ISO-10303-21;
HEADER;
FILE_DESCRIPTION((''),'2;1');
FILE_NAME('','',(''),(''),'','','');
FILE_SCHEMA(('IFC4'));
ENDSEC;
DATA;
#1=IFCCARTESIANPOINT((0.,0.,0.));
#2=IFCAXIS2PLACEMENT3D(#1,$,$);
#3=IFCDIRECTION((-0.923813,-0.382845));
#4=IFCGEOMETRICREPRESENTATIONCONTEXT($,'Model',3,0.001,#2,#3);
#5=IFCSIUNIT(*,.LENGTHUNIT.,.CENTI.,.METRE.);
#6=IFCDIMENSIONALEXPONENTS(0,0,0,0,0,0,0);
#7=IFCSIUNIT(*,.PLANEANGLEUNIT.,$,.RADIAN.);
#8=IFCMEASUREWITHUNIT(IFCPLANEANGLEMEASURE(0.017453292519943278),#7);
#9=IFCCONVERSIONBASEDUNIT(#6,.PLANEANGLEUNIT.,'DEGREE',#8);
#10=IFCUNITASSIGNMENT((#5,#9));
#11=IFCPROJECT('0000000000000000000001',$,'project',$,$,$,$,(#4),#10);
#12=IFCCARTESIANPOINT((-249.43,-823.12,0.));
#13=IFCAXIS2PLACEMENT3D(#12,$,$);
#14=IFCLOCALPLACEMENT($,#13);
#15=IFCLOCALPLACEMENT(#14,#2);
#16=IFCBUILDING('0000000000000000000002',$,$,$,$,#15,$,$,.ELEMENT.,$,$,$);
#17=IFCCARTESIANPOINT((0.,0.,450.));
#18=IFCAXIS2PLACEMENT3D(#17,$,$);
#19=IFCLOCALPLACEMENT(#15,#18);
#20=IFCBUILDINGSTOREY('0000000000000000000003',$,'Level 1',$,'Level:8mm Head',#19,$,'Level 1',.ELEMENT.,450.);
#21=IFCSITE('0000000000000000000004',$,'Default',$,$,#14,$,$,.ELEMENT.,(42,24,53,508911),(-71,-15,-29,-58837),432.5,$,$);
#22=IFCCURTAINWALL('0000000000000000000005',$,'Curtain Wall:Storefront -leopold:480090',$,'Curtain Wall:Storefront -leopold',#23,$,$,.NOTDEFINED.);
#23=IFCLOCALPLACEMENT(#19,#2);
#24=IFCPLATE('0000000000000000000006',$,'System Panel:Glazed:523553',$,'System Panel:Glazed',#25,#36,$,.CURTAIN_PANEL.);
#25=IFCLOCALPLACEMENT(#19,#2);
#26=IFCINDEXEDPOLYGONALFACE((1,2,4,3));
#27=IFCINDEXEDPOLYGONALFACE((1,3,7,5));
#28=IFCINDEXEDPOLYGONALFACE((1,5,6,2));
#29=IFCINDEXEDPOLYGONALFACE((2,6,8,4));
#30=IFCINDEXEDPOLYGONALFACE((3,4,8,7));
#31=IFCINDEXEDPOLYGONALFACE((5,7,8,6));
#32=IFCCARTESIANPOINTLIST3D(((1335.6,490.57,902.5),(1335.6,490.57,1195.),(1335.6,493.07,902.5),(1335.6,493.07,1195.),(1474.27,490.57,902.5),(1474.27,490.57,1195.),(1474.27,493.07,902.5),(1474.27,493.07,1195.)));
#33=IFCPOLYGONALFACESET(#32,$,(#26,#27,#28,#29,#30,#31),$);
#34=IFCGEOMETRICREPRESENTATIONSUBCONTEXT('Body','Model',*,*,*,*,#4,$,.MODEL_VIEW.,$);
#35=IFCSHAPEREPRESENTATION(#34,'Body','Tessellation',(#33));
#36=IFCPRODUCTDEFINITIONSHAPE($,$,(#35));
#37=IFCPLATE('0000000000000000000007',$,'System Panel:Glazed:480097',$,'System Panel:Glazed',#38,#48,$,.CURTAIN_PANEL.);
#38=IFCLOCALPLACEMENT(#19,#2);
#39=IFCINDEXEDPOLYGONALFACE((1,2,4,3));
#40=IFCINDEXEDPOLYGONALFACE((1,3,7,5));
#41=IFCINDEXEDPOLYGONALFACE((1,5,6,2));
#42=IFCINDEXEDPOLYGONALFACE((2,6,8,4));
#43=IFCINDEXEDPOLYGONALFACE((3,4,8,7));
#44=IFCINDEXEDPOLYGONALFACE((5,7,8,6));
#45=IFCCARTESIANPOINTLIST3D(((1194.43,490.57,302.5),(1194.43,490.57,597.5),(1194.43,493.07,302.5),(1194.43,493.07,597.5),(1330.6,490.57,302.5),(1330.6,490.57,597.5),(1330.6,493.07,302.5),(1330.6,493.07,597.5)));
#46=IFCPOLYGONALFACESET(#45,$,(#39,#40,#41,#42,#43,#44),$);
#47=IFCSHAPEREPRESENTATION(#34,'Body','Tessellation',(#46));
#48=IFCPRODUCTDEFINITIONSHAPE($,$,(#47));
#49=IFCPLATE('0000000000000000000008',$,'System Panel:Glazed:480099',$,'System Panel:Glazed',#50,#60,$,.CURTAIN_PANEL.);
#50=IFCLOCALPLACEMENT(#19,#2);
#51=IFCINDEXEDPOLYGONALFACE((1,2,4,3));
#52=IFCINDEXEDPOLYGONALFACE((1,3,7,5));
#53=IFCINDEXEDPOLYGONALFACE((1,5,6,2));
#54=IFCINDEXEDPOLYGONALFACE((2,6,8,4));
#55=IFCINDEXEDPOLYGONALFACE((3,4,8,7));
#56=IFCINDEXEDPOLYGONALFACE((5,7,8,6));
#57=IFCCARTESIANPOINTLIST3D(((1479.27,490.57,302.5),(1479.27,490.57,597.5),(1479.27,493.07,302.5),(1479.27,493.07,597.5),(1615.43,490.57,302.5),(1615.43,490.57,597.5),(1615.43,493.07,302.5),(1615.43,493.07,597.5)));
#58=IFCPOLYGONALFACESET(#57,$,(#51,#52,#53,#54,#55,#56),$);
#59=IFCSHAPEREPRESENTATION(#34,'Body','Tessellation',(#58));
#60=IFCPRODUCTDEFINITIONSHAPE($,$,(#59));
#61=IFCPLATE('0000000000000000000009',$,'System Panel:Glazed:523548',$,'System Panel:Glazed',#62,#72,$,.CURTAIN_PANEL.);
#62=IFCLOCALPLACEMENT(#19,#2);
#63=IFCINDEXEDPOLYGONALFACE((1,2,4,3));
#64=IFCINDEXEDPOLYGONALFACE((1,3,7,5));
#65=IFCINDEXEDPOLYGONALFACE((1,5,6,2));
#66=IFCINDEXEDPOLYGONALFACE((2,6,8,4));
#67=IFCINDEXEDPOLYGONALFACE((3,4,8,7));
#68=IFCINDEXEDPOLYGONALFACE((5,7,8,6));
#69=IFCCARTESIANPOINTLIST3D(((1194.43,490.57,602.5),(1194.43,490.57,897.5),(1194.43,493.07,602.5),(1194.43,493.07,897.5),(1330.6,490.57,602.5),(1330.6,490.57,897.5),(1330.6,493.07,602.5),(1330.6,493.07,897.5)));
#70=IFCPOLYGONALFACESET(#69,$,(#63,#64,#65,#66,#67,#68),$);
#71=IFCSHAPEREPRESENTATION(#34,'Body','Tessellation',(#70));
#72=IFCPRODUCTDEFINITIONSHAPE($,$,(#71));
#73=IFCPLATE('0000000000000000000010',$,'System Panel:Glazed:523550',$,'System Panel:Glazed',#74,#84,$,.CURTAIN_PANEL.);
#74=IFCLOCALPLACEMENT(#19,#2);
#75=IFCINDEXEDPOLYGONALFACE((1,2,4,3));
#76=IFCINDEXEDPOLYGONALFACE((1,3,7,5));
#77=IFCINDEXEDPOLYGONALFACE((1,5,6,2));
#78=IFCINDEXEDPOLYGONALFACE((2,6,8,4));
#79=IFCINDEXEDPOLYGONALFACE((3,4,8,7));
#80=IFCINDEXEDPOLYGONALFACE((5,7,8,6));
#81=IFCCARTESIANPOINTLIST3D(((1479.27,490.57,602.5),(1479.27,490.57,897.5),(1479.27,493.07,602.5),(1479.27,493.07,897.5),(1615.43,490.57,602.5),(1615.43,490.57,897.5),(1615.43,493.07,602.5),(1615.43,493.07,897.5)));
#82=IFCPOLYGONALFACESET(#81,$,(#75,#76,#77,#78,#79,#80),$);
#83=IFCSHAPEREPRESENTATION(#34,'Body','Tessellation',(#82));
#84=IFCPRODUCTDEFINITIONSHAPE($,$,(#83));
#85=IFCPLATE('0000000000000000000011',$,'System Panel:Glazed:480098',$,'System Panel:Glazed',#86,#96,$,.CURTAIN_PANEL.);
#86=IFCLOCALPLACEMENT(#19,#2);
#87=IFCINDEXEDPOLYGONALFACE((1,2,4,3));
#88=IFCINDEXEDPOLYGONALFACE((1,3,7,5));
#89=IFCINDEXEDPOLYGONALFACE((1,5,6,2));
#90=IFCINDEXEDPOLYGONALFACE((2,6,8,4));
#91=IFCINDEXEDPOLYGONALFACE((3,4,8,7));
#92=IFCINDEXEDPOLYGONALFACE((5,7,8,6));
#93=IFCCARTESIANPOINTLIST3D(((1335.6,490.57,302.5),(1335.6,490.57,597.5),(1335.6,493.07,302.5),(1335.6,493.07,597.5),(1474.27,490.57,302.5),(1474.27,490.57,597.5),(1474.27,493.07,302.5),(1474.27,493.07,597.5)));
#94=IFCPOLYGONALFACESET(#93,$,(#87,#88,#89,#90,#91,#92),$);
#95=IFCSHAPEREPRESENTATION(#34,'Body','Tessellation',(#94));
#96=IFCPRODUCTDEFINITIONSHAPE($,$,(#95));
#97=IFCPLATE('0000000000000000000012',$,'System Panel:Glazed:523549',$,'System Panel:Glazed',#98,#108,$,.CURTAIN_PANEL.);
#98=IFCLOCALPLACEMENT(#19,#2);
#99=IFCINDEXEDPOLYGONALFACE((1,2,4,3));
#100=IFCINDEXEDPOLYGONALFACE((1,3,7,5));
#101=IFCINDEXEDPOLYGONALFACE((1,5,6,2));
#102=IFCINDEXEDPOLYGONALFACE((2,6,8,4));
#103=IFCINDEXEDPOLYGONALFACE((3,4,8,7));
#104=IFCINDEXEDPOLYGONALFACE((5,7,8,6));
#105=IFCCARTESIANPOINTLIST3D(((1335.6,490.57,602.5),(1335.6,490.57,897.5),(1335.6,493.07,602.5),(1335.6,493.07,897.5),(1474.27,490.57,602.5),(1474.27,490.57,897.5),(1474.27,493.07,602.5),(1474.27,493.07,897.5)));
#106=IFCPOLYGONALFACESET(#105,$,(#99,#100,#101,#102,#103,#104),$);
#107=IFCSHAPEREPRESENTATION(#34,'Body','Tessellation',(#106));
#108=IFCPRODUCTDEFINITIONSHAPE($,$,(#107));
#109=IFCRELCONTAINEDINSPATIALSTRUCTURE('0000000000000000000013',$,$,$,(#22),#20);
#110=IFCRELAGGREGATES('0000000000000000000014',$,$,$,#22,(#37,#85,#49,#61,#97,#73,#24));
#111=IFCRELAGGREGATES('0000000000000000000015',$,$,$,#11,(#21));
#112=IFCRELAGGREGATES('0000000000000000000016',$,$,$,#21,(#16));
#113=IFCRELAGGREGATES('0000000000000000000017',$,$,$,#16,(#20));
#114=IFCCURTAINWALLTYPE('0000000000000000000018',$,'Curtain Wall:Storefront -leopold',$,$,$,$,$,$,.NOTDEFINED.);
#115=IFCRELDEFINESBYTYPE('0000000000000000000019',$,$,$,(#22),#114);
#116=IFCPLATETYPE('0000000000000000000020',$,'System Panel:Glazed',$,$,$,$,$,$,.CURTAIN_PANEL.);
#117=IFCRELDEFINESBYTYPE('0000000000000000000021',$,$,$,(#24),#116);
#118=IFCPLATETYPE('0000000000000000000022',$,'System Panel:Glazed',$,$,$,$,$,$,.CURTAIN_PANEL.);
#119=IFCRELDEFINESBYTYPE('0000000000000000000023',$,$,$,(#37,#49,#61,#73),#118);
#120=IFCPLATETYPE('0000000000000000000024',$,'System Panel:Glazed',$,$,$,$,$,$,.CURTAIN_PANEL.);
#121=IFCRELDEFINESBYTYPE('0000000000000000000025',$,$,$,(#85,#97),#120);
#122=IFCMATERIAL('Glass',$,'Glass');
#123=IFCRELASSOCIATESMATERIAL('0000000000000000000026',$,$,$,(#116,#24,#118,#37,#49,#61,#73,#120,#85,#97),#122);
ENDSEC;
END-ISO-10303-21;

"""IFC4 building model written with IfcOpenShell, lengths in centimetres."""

from ifc_helpers import new_model, entity, si_unit, converted_unit, direction, frame, origin, place, context, subcontext, project, spatial, indexed_curve, outline, extrude, source, transform, mapped, material, type_object, type_shapes, element, aggregate, save


model = new_model("IFC4")

# Units and contexts
model_context = context("Model", 3, precision=0.001, world=origin(), true_north=direction((-0.923813, -0.382845)))
body_context = subcontext(model_context, "Body", "Model", "MODEL_VIEW")
ifc_project = project(units=[si_unit("LENGTHUNIT", "METRE", prefix="CENTI"), converted_unit("PLANEANGLEUNIT", "DEGREE", entity("IfcPlaneAngleMeasure", 0.017453292519943278), si_unit("PLANEANGLEUNIT", "RADIAN"), dimensions=[0, 0, 0, 0, 0, 0, 0])], contexts=[model_context])

# Site, building, storey
site_placement = place(None, frame((-249.43, -823.12, 0.0)))
site = spatial("IfcSite", under=ifc_project, at=site_placement, Name="Default", CompositionType="ELEMENT", RefLatitude=(42, 24, 53, 508911), RefLongitude=(-71, -15, -29, -58837), RefElevation=432.5)
building_placement = place(site_placement, origin())
building = spatial("IfcBuilding", under=site, at=building_placement, CompositionType="ELEMENT")
storey_placement = place(building_placement, frame((0.0, 0.0, 450.0)))
storey = spatial("IfcBuildingStorey", under=building, at=storey_placement, Name="Level 1", ObjectType="Level:8mm Head", LongName="Level 1", CompositionType="ELEMENT", Elevation=450.0)

# Curtain wall, plates
curtain_wall_type = type_object("IfcCurtainWallType", Name="Curtain Wall:Storefront -leopold", PredefinedType="NOTDEFINED")
curtain_wall_placement = place(storey_placement, frame((0.0, 0.0, -450.0)))
curtain_wall = element("IfcCurtainWall", 1, at=curtain_wall_placement, inside=storey, type_object=curtain_wall_type, Name="Curtain Wall:Storefront -leopold:480090", ObjectType="Curtain Wall:Storefront -leopold", PredefinedType="NOTDEFINED")
ifc_material_1 = material(Name="Glass", Category="Glass")
plate_type_1 = type_object("IfcPlateType", Name="System Panel:Glazed", PredefinedType="CURTAIN_PANEL", material=ifc_material_1)
shared_shape_1 = source(origin(), body_context, "Body", "SweptSolid", [
    extrude(outline(indexed_curve([(-1.25, -69.33), (1.25, -69.33), (1.25, 69.33), (-1.25, 69.33), (-1.25, -69.33)], self_intersect=False)), frame((0.0, 3.7, 0.0), z_axis=(0.0, 0.0, 1.0), x_axis=(0.0, 1.0, 0.0)), (0.0, 0.0, 1.0), 292.5),
])
type_shapes(plate_type_1, [shared_shape_1])
plate_1_placement = place(curtain_wall_placement, frame((1404.93, 488.12, 1352.5)))
plate_1 = element("IfcPlate", 2, at=plate_1_placement, type_object=plate_type_1, material=ifc_material_1, Name="System Panel:Glazed:523553", ObjectType="System Panel:Glazed", PredefinedType="CURTAIN_PANEL", context=body_context, shape_type="MappedRepresentation", body=[
    mapped(shared_shape_1, transform((0.0, 0.0, 0.0), scale=1.0)),
])
plate_type_2 = type_object("IfcPlateType", Name="System Panel:Glazed", PredefinedType="CURTAIN_PANEL", material=ifc_material_1)
shared_shape_2 = source(origin(), body_context, "Body", "SweptSolid", [
    extrude(outline(indexed_curve([(-1.25, -68.08), (1.25, -68.08), (1.25, 68.08), (-1.25, 68.08), (-1.25, -68.08)], self_intersect=False)), frame((0.0, 3.7, 0.0), z_axis=(0.0, 0.0, 1.0), x_axis=(0.0, 1.0, 0.0)), (0.0, 0.0, 1.0), 295.0),
])
type_shapes(plate_type_2, [shared_shape_2])
plate_2_placement = place(curtain_wall_placement, frame((1262.52, 488.12, 752.5)))
plate_2 = element("IfcPlate", 3, at=plate_2_placement, type_object=plate_type_2, material=ifc_material_1, Name="System Panel:Glazed:480097", ObjectType="System Panel:Glazed", PredefinedType="CURTAIN_PANEL", context=body_context, shape_type="MappedRepresentation", body=[
    mapped(shared_shape_2, transform((0.0, 0.0, 0.0), scale=1.0)),
])
plate_3_placement = place(curtain_wall_placement, frame((1547.35, 488.12, 752.5)))
plate_3 = element("IfcPlate", 4, at=plate_3_placement, type_object=plate_type_2, material=ifc_material_1, Name="System Panel:Glazed:480099", ObjectType="System Panel:Glazed", PredefinedType="CURTAIN_PANEL", context=body_context, shape_type="MappedRepresentation", body=[
    mapped(shared_shape_2, transform((0.0, 0.0, 0.0), scale=1.0)),
])
plate_4_placement = place(curtain_wall_placement, frame((1262.52, 488.12, 1052.5)))
plate_4 = element("IfcPlate", 5, at=plate_4_placement, type_object=plate_type_2, material=ifc_material_1, Name="System Panel:Glazed:523548", ObjectType="System Panel:Glazed", PredefinedType="CURTAIN_PANEL", context=body_context, shape_type="MappedRepresentation", body=[
    mapped(shared_shape_2, transform((0.0, 0.0, 0.0), scale=1.0)),
])
plate_5_placement = place(curtain_wall_placement, frame((1547.35, 488.12, 1052.5)))
plate_5 = element("IfcPlate", 6, at=plate_5_placement, type_object=plate_type_2, material=ifc_material_1, Name="System Panel:Glazed:523550", ObjectType="System Panel:Glazed", PredefinedType="CURTAIN_PANEL", context=body_context, shape_type="MappedRepresentation", body=[
    mapped(shared_shape_2, transform((0.0, 0.0, 0.0), scale=1.0)),
])
plate_type_3 = type_object("IfcPlateType", Name="System Panel:Glazed", PredefinedType="CURTAIN_PANEL", material=ifc_material_1)
shared_shape_3 = source(origin(), body_context, "Body", "SweptSolid", [
    extrude(outline(indexed_curve([(-1.25, -69.33), (1.25, -69.33), (1.25, 69.33), (-1.25, 69.33), (-1.25, -69.33)], self_intersect=False)), frame((0.0, 3.7, 0.0), z_axis=(0.0, 0.0, 1.0), x_axis=(0.0, 1.0, 0.0)), (0.0, 0.0, 1.0), 295.0),
])
type_shapes(plate_type_3, [shared_shape_3])
plate_6_placement = place(curtain_wall_placement, frame((1404.93, 488.12, 752.5)))
plate_6 = element("IfcPlate", 7, at=plate_6_placement, type_object=plate_type_3, material=ifc_material_1, Name="System Panel:Glazed:480098", ObjectType="System Panel:Glazed", PredefinedType="CURTAIN_PANEL", context=body_context, shape_type="MappedRepresentation", body=[
    mapped(shared_shape_3, transform((0.0, 0.0, 0.0), scale=1.0)),
])
plate_7_placement = place(curtain_wall_placement, frame((1404.93, 488.12, 1052.5)))
plate_7 = element("IfcPlate", 8, at=plate_7_placement, type_object=plate_type_3, material=ifc_material_1, Name="System Panel:Glazed:523549", ObjectType="System Panel:Glazed", PredefinedType="CURTAIN_PANEL", context=body_context, shape_type="MappedRepresentation", body=[
    mapped(shared_shape_3, transform((0.0, 0.0, 0.0), scale=1.0)),
])
aggregate(curtain_wall, [plate_2, plate_6, plate_3, plate_4, plate_7, plate_5, plate_1])

save(model, "model.ifc")
